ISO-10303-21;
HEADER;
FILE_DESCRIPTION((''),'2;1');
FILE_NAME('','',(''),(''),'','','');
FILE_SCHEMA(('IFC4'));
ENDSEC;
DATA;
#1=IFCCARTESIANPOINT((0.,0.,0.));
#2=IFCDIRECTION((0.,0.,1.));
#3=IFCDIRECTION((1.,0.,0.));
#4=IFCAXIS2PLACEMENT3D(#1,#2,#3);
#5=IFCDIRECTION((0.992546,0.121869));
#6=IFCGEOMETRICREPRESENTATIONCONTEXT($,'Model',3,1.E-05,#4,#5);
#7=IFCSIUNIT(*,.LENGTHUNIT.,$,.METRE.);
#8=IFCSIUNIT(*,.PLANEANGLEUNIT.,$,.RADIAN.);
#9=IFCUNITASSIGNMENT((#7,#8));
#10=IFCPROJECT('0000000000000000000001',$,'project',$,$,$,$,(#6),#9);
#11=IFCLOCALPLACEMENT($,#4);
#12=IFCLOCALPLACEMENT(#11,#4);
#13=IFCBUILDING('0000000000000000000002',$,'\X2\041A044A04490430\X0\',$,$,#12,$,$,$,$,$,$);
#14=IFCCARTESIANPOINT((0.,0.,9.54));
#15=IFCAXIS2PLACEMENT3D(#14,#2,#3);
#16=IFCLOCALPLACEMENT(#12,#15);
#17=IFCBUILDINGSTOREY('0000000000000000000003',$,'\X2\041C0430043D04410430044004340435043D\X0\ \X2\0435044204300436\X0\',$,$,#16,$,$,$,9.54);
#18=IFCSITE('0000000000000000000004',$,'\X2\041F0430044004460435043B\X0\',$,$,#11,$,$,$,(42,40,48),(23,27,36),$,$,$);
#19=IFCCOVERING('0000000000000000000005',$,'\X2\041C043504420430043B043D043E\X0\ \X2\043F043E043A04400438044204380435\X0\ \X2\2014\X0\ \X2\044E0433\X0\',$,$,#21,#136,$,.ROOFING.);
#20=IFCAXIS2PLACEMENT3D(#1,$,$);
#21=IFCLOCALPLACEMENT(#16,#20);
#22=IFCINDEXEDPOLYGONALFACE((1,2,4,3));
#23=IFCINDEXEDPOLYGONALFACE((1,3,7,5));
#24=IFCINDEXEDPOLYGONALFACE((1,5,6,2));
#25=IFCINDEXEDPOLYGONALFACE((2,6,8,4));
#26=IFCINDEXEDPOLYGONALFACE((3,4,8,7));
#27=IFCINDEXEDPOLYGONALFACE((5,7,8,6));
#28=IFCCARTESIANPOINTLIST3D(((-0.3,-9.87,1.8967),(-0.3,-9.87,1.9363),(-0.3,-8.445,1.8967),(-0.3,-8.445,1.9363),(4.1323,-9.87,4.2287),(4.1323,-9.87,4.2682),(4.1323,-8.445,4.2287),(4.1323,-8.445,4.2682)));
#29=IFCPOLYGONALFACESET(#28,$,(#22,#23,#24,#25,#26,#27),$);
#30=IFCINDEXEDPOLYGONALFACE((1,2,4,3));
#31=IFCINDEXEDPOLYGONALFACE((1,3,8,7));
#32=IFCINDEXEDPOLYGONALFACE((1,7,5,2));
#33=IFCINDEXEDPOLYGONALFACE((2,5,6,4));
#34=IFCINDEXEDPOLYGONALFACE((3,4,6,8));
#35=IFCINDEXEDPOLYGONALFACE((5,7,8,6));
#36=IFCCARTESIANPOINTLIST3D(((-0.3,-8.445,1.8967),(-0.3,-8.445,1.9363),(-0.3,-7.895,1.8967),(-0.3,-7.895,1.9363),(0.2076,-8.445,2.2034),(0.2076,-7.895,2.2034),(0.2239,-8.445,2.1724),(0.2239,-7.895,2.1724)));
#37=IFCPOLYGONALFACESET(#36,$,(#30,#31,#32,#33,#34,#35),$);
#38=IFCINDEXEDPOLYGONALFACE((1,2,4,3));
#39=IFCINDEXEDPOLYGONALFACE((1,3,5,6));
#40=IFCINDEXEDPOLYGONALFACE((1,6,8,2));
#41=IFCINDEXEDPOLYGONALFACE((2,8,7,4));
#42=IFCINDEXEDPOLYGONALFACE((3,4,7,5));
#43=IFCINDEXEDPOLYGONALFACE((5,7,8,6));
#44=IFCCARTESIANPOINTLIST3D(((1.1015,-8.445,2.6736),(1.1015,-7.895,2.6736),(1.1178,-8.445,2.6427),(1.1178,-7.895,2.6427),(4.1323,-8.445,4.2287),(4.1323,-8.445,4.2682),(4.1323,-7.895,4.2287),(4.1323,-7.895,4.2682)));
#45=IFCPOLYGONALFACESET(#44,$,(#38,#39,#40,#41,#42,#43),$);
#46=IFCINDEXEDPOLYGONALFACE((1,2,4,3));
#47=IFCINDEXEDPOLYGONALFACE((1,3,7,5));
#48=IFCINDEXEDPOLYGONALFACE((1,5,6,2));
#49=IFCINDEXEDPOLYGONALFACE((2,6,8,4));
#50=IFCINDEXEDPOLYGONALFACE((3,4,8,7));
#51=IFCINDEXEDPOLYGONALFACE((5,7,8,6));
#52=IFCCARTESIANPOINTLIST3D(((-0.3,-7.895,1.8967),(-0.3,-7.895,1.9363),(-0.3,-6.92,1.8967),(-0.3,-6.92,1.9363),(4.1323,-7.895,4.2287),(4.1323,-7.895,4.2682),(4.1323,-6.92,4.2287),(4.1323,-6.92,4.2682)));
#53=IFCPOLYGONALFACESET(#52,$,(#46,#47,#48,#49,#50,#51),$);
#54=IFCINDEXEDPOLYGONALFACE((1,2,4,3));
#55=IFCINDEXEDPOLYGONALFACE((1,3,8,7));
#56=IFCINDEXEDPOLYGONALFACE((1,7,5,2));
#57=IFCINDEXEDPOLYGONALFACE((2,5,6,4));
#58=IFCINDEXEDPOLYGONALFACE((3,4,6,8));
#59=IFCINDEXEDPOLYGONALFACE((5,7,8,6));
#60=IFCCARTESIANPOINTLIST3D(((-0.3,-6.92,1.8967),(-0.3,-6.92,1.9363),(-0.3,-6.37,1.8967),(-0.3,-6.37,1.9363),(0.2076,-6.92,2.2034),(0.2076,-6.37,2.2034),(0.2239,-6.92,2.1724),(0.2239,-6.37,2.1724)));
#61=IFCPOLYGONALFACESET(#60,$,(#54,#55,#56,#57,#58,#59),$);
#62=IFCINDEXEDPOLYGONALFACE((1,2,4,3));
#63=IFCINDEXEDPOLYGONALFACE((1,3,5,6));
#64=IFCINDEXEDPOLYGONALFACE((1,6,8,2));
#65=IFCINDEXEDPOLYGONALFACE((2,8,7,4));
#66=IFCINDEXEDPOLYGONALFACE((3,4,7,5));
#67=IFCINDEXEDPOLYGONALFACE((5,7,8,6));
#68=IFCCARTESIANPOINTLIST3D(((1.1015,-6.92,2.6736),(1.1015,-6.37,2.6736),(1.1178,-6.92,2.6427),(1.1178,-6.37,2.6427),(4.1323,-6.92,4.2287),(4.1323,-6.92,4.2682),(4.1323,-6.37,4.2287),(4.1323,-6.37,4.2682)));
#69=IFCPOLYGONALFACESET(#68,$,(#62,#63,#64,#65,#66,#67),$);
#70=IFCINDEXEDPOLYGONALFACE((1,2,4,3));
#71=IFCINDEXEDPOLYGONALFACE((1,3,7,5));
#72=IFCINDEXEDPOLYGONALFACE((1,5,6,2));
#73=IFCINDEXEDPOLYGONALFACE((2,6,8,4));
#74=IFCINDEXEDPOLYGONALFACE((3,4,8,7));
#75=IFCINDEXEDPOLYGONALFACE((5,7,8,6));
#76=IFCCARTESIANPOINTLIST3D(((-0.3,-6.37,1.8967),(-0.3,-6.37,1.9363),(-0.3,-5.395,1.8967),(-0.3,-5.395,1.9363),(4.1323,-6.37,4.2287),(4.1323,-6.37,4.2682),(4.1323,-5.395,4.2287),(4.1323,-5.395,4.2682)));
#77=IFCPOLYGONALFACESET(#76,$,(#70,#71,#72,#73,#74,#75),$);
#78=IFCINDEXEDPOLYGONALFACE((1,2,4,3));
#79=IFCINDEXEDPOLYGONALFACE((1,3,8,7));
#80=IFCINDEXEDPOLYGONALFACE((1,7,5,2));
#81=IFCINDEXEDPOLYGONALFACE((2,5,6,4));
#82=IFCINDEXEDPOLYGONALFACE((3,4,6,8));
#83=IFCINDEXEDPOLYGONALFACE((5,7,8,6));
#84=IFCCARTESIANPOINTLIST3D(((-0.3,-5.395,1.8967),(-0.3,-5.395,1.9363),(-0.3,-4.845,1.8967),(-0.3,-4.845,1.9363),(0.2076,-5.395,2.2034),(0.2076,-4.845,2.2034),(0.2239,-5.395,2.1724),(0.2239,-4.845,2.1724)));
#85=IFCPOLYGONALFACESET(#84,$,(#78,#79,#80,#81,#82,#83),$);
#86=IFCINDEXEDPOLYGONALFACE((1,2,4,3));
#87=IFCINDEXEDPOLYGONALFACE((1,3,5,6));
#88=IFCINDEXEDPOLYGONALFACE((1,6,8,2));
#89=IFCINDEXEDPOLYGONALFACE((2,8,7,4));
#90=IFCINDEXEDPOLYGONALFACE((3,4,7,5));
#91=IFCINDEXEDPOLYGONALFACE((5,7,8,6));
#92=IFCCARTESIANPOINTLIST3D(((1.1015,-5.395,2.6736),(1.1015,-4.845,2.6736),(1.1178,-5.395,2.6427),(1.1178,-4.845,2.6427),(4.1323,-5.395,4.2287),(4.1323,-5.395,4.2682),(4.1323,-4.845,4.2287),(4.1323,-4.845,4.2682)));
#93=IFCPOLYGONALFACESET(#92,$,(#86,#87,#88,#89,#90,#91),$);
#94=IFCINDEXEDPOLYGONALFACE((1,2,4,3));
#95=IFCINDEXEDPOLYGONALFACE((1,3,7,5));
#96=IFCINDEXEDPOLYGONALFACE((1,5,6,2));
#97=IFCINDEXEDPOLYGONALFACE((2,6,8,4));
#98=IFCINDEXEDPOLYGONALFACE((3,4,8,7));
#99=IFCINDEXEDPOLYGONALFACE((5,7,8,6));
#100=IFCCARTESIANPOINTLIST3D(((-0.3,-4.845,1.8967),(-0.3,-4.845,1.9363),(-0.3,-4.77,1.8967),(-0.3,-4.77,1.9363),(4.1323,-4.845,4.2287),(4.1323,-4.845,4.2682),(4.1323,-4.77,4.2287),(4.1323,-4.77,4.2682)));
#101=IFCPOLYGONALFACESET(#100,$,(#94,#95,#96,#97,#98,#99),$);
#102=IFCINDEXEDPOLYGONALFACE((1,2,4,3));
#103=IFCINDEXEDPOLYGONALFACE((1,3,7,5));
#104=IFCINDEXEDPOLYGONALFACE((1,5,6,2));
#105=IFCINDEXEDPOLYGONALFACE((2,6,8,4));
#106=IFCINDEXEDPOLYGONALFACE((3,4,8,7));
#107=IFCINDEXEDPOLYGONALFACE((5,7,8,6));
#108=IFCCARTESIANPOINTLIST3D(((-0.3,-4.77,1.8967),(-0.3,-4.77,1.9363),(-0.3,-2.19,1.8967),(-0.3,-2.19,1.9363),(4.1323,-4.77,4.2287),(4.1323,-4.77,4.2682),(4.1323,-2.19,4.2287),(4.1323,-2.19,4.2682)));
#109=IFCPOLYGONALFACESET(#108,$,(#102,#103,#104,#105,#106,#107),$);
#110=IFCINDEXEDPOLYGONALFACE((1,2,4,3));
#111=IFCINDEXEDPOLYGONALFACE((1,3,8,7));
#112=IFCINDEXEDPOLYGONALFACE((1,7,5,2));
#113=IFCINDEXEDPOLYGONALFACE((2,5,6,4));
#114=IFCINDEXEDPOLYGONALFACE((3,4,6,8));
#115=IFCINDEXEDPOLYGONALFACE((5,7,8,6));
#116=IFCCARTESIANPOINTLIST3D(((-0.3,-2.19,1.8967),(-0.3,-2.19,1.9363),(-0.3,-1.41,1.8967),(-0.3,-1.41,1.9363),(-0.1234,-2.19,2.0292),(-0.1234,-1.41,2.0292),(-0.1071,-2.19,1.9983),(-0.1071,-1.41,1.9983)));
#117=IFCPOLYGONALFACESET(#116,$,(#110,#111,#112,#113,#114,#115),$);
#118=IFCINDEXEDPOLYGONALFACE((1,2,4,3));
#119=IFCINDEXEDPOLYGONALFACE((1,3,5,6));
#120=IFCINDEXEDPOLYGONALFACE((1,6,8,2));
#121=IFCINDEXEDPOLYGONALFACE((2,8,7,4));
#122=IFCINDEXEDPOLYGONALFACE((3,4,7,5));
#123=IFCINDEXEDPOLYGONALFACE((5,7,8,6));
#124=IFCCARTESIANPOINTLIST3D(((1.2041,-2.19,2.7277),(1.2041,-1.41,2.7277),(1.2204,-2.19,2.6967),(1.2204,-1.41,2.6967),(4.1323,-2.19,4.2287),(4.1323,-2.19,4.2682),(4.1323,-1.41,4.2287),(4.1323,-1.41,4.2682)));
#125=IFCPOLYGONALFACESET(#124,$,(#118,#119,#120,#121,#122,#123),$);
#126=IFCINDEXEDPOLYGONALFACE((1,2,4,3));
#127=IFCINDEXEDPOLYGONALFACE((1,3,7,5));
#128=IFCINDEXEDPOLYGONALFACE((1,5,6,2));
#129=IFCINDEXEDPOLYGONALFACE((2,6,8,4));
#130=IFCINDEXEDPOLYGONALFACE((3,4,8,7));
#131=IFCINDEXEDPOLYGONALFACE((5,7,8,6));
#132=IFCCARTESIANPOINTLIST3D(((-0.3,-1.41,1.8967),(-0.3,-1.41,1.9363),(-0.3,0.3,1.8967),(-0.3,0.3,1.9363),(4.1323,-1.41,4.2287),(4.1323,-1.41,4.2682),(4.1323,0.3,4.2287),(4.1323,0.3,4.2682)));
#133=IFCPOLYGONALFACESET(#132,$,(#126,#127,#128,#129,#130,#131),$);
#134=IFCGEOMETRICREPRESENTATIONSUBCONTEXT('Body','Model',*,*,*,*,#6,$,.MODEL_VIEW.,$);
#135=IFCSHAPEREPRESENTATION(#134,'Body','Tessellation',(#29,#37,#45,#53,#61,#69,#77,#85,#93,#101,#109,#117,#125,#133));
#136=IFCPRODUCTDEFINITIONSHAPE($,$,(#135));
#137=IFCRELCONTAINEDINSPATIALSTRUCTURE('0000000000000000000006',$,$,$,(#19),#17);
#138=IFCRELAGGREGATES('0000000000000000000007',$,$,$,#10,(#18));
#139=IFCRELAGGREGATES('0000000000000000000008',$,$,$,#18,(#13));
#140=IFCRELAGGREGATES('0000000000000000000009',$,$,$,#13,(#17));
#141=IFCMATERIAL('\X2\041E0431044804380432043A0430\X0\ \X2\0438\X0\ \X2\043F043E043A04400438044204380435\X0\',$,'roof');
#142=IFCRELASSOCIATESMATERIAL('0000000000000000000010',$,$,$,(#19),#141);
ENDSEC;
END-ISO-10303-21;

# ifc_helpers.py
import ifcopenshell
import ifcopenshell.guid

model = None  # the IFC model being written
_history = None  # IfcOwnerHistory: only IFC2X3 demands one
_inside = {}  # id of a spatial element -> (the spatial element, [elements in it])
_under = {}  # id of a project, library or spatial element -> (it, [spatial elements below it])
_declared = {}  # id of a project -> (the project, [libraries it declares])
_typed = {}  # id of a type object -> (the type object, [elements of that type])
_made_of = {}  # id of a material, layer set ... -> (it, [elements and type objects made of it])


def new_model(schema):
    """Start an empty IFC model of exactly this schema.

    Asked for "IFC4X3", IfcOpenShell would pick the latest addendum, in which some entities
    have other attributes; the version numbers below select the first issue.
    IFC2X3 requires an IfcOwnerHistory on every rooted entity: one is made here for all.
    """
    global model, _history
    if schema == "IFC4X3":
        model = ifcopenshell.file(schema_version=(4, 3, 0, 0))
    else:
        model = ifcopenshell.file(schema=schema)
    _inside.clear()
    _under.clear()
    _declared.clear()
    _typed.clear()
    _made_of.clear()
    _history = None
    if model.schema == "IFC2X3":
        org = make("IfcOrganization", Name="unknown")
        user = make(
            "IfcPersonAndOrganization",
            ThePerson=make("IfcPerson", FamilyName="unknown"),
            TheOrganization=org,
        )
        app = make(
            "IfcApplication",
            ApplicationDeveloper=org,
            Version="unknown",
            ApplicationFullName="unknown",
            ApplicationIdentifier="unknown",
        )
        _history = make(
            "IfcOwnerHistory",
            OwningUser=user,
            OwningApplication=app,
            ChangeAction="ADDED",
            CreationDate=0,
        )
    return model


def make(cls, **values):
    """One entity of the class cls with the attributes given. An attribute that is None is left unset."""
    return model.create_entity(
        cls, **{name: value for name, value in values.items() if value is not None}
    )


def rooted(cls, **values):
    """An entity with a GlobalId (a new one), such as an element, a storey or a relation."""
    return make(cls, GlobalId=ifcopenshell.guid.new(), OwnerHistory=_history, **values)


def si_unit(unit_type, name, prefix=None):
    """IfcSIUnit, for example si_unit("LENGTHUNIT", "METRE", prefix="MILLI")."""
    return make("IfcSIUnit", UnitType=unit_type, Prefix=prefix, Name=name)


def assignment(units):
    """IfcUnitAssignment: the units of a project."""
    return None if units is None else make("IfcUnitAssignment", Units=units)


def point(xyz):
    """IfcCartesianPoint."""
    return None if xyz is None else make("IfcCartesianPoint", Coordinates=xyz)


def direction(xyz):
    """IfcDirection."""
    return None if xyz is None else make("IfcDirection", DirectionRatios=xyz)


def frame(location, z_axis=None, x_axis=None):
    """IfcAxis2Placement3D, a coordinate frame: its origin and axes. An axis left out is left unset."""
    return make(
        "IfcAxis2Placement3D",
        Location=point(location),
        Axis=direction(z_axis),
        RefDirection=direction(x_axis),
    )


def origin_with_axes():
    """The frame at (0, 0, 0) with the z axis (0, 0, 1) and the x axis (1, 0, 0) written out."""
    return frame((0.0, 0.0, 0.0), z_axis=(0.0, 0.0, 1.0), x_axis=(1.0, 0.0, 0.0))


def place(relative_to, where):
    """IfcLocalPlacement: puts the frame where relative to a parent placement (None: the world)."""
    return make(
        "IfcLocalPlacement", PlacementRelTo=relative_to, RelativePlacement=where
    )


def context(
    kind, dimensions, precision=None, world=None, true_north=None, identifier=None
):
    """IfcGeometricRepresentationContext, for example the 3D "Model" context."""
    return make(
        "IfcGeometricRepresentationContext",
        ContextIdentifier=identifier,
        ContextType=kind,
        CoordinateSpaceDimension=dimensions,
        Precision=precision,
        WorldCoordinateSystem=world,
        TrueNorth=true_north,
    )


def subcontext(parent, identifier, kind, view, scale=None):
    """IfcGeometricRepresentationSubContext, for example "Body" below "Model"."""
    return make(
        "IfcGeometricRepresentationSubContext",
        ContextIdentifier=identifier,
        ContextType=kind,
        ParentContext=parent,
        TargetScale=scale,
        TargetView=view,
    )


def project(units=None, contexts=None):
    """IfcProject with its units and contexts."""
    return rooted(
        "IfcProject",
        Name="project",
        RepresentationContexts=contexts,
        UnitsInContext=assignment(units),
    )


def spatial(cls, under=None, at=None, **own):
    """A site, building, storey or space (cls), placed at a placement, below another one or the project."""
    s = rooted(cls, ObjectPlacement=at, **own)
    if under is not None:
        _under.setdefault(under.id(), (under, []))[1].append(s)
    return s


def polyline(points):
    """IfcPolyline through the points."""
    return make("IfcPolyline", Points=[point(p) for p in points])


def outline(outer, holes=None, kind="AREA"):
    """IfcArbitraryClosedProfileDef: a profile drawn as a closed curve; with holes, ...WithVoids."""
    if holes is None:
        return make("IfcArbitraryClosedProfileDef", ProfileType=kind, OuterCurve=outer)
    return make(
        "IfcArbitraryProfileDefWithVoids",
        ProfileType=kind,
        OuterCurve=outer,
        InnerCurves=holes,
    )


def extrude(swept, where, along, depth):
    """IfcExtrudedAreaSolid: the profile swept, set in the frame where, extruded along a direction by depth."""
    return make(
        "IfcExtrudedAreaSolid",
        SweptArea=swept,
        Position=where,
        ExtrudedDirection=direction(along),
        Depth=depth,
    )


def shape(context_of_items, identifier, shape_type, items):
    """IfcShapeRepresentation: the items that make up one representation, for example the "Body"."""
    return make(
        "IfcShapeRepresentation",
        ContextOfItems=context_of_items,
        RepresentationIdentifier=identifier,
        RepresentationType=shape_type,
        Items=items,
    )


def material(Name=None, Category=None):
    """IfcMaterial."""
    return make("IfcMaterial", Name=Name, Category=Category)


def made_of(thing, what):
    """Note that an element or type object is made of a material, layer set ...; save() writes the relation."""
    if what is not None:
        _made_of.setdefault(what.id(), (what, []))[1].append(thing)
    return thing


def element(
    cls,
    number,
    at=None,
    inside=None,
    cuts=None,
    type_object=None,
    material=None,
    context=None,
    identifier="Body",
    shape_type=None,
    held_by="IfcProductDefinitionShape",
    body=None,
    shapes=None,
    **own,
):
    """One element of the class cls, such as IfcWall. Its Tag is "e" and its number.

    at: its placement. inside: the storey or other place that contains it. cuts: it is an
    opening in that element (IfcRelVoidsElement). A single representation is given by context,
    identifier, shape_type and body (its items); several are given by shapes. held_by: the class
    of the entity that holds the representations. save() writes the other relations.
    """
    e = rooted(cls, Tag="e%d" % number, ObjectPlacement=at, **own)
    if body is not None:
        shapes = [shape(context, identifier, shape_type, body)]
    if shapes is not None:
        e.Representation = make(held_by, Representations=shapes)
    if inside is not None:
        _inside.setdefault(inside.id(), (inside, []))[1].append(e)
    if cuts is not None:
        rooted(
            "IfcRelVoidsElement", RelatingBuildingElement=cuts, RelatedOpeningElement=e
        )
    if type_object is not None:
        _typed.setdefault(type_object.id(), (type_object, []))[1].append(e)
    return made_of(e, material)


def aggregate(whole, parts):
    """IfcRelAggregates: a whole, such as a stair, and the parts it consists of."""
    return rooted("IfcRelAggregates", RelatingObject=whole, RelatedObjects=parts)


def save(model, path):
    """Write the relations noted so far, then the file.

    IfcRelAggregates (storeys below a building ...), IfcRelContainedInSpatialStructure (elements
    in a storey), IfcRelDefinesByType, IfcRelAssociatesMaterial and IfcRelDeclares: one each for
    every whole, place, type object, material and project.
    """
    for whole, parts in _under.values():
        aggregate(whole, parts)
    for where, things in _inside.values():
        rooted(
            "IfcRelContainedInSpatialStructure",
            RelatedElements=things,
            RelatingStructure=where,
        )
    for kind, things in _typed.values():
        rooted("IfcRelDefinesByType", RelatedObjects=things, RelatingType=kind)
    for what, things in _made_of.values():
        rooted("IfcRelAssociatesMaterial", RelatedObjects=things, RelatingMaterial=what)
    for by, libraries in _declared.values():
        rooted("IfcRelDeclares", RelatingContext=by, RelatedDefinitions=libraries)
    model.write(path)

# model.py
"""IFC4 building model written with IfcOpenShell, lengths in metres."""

from ifc_helpers import new_model, si_unit, direction, frame, origin_with_axes, place, context, subcontext, project, spatial, polyline, outline, extrude, material, element, save


model = new_model("IFC4")

# Units and contexts
model_context = context("Model", 3, precision=1e-05, world=origin_with_axes(), true_north=direction((0.992546, 0.121869)))
body_context = subcontext(model_context, "Body", "Model", "MODEL_VIEW")
ifc_project = project(units=[si_unit("LENGTHUNIT", "METRE"), si_unit("PLANEANGLEUNIT", "RADIAN")], contexts=[model_context])

# Site, building, storey
site_placement = place(None, origin_with_axes())
site = spatial("IfcSite", under=ifc_project, at=site_placement, Name="Парцел", RefLatitude=(42, 40, 48), RefLongitude=(23, 27, 36))
building_placement = place(site_placement, origin_with_axes())
building = spatial("IfcBuilding", under=site, at=building_placement, Name="Къща")
storey_placement = place(building_placement, frame((0.0, 0.0, 9.54), z_axis=(0.0, 0.0, 1.0), x_axis=(1.0, 0.0, 0.0)))
storey = spatial("IfcBuildingStorey", under=building, at=storey_placement, Name="Мансарден етаж", Elevation=9.54)

# Covering
ifc_material_1 = material(Name="Обшивка и покритие", Category="roof")
covering_1_placement = place(storey_placement, origin_with_axes())
element("IfcCovering", 1, at=covering_1_placement, inside=storey, material=ifc_material_1, Name="Метално покритие — юг", PredefinedType="ROOFING", context=body_context, shape_type="SweptSolid", body=[
    extrude(outline(polyline([(-0.3, -1.8967), (4.1323, -4.2287), (4.1323, -4.2682), (-0.3, -1.9363), (-0.3, -1.8967)])), frame((0.0, -9.87, 0.0), z_axis=(0.0, 1.0, 0.0), x_axis=(1.0, 0.0, 0.0)), (0.0, 0.0, 1.0), 1.425),
    extrude(outline(polyline([(-0.3, -1.8967), (0.2239, -2.1724), (0.2076, -2.2034), (-0.3, -1.9363), (-0.3, -1.8967)])), frame((0.0, -8.445, 0.0), z_axis=(0.0, 1.0, 0.0), x_axis=(1.0, 0.0, 0.0)), (0.0, 0.0, 1.0), 0.55),
    extrude(outline(polyline([(1.1178, -2.6427), (4.1323, -4.2287), (4.1323, -4.2682), (1.1015, -2.6736), (1.1178, -2.6427)])), frame((0.0, -8.445, 0.0), z_axis=(0.0, 1.0, 0.0), x_axis=(1.0, 0.0, 0.0)), (0.0, 0.0, 1.0), 0.55),
    extrude(outline(polyline([(-0.3, -1.8967), (4.1323, -4.2287), (4.1323, -4.2682), (-0.3, -1.9363), (-0.3, -1.8967)])), frame((0.0, -7.895, 0.0), z_axis=(0.0, 1.0, 0.0), x_axis=(1.0, 0.0, 0.0)), (0.0, 0.0, 1.0), 0.975),
    extrude(outline(polyline([(-0.3, -1.8967), (0.2239, -2.1724), (0.2076, -2.2034), (-0.3, -1.9363), (-0.3, -1.8967)])), frame((0.0, -6.92, 0.0), z_axis=(0.0, 1.0, 0.0), x_axis=(1.0, 0.0, 0.0)), (0.0, 0.0, 1.0), 0.55),
    extrude(outline(polyline([(1.1178, -2.6427), (4.1323, -4.2287), (4.1323, -4.2682), (1.1015, -2.6736), (1.1178, -2.6427)])), frame((0.0, -6.92, 0.0), z_axis=(0.0, 1.0, 0.0), x_axis=(1.0, 0.0, 0.0)), (0.0, 0.0, 1.0), 0.55),
    extrude(outline(polyline([(-0.3, -1.8967), (4.1323, -4.2287), (4.1323, -4.2682), (-0.3, -1.9363), (-0.3, -1.8967)])), frame((0.0, -6.37, 0.0), z_axis=(0.0, 1.0, 0.0), x_axis=(1.0, 0.0, 0.0)), (0.0, 0.0, 1.0), 0.975),
    extrude(outline(polyline([(-0.3, -1.8967), (0.2239, -2.1724), (0.2076, -2.2034), (-0.3, -1.9363), (-0.3, -1.8967)])), frame((0.0, -5.395, 0.0), z_axis=(0.0, 1.0, 0.0), x_axis=(1.0, 0.0, 0.0)), (0.0, 0.0, 1.0), 0.55),
    extrude(outline(polyline([(1.1178, -2.6427), (4.1323, -4.2287), (4.1323, -4.2682), (1.1015, -2.6736), (1.1178, -2.6427)])), frame((0.0, -5.395, 0.0), z_axis=(0.0, 1.0, 0.0), x_axis=(1.0, 0.0, 0.0)), (0.0, 0.0, 1.0), 0.55),
    extrude(outline(polyline([(-0.3, -1.8967), (4.1323, -4.2287), (4.1323, -4.2682), (-0.3, -1.9363), (-0.3, -1.8967)])), frame((0.0, -4.845, 0.0), z_axis=(0.0, 1.0, 0.0), x_axis=(1.0, 0.0, 0.0)), (0.0, 0.0, 1.0), 0.075),
    extrude(outline(polyline([(-0.3, -1.8967), (4.1323, -4.2287), (4.1323, -4.2682), (-0.3, -1.9363), (-0.3, -1.8967)])), frame((0.0, -4.77, 0.0), z_axis=(0.0, 1.0, 0.0), x_axis=(1.0, 0.0, 0.0)), (0.0, 0.0, 1.0), 2.58),
    extrude(outline(polyline([(-0.3, -1.8967), (-0.1071, -1.9983), (-0.1234, -2.0292), (-0.3, -1.9363), (-0.3, -1.8967)])), frame((0.0, -2.19, 0.0), z_axis=(0.0, 1.0, 0.0), x_axis=(1.0, 0.0, 0.0)), (0.0, 0.0, 1.0), 0.78),
    extrude(outline(polyline([(1.2204, -2.6967), (4.1323, -4.2287), (4.1323, -4.2682), (1.2041, -2.7277), (1.2204, -2.6967)])), frame((0.0, -2.19, 0.0), z_axis=(0.0, 1.0, 0.0), x_axis=(1.0, 0.0, 0.0)), (0.0, 0.0, 1.0), 0.78),
    extrude(outline(polyline([(-0.3, -1.8967), (4.1323, -4.2287), (4.1323, -4.2682), (-0.3, -1.9363), (-0.3, -1.8967)])), frame((0.0, -1.41, 0.0), z_axis=(0.0, 1.0, 0.0), x_axis=(1.0, 0.0, 0.0)), (0.0, 0.0, 1.0), 1.71),
])

save(model, "model.ifc")
